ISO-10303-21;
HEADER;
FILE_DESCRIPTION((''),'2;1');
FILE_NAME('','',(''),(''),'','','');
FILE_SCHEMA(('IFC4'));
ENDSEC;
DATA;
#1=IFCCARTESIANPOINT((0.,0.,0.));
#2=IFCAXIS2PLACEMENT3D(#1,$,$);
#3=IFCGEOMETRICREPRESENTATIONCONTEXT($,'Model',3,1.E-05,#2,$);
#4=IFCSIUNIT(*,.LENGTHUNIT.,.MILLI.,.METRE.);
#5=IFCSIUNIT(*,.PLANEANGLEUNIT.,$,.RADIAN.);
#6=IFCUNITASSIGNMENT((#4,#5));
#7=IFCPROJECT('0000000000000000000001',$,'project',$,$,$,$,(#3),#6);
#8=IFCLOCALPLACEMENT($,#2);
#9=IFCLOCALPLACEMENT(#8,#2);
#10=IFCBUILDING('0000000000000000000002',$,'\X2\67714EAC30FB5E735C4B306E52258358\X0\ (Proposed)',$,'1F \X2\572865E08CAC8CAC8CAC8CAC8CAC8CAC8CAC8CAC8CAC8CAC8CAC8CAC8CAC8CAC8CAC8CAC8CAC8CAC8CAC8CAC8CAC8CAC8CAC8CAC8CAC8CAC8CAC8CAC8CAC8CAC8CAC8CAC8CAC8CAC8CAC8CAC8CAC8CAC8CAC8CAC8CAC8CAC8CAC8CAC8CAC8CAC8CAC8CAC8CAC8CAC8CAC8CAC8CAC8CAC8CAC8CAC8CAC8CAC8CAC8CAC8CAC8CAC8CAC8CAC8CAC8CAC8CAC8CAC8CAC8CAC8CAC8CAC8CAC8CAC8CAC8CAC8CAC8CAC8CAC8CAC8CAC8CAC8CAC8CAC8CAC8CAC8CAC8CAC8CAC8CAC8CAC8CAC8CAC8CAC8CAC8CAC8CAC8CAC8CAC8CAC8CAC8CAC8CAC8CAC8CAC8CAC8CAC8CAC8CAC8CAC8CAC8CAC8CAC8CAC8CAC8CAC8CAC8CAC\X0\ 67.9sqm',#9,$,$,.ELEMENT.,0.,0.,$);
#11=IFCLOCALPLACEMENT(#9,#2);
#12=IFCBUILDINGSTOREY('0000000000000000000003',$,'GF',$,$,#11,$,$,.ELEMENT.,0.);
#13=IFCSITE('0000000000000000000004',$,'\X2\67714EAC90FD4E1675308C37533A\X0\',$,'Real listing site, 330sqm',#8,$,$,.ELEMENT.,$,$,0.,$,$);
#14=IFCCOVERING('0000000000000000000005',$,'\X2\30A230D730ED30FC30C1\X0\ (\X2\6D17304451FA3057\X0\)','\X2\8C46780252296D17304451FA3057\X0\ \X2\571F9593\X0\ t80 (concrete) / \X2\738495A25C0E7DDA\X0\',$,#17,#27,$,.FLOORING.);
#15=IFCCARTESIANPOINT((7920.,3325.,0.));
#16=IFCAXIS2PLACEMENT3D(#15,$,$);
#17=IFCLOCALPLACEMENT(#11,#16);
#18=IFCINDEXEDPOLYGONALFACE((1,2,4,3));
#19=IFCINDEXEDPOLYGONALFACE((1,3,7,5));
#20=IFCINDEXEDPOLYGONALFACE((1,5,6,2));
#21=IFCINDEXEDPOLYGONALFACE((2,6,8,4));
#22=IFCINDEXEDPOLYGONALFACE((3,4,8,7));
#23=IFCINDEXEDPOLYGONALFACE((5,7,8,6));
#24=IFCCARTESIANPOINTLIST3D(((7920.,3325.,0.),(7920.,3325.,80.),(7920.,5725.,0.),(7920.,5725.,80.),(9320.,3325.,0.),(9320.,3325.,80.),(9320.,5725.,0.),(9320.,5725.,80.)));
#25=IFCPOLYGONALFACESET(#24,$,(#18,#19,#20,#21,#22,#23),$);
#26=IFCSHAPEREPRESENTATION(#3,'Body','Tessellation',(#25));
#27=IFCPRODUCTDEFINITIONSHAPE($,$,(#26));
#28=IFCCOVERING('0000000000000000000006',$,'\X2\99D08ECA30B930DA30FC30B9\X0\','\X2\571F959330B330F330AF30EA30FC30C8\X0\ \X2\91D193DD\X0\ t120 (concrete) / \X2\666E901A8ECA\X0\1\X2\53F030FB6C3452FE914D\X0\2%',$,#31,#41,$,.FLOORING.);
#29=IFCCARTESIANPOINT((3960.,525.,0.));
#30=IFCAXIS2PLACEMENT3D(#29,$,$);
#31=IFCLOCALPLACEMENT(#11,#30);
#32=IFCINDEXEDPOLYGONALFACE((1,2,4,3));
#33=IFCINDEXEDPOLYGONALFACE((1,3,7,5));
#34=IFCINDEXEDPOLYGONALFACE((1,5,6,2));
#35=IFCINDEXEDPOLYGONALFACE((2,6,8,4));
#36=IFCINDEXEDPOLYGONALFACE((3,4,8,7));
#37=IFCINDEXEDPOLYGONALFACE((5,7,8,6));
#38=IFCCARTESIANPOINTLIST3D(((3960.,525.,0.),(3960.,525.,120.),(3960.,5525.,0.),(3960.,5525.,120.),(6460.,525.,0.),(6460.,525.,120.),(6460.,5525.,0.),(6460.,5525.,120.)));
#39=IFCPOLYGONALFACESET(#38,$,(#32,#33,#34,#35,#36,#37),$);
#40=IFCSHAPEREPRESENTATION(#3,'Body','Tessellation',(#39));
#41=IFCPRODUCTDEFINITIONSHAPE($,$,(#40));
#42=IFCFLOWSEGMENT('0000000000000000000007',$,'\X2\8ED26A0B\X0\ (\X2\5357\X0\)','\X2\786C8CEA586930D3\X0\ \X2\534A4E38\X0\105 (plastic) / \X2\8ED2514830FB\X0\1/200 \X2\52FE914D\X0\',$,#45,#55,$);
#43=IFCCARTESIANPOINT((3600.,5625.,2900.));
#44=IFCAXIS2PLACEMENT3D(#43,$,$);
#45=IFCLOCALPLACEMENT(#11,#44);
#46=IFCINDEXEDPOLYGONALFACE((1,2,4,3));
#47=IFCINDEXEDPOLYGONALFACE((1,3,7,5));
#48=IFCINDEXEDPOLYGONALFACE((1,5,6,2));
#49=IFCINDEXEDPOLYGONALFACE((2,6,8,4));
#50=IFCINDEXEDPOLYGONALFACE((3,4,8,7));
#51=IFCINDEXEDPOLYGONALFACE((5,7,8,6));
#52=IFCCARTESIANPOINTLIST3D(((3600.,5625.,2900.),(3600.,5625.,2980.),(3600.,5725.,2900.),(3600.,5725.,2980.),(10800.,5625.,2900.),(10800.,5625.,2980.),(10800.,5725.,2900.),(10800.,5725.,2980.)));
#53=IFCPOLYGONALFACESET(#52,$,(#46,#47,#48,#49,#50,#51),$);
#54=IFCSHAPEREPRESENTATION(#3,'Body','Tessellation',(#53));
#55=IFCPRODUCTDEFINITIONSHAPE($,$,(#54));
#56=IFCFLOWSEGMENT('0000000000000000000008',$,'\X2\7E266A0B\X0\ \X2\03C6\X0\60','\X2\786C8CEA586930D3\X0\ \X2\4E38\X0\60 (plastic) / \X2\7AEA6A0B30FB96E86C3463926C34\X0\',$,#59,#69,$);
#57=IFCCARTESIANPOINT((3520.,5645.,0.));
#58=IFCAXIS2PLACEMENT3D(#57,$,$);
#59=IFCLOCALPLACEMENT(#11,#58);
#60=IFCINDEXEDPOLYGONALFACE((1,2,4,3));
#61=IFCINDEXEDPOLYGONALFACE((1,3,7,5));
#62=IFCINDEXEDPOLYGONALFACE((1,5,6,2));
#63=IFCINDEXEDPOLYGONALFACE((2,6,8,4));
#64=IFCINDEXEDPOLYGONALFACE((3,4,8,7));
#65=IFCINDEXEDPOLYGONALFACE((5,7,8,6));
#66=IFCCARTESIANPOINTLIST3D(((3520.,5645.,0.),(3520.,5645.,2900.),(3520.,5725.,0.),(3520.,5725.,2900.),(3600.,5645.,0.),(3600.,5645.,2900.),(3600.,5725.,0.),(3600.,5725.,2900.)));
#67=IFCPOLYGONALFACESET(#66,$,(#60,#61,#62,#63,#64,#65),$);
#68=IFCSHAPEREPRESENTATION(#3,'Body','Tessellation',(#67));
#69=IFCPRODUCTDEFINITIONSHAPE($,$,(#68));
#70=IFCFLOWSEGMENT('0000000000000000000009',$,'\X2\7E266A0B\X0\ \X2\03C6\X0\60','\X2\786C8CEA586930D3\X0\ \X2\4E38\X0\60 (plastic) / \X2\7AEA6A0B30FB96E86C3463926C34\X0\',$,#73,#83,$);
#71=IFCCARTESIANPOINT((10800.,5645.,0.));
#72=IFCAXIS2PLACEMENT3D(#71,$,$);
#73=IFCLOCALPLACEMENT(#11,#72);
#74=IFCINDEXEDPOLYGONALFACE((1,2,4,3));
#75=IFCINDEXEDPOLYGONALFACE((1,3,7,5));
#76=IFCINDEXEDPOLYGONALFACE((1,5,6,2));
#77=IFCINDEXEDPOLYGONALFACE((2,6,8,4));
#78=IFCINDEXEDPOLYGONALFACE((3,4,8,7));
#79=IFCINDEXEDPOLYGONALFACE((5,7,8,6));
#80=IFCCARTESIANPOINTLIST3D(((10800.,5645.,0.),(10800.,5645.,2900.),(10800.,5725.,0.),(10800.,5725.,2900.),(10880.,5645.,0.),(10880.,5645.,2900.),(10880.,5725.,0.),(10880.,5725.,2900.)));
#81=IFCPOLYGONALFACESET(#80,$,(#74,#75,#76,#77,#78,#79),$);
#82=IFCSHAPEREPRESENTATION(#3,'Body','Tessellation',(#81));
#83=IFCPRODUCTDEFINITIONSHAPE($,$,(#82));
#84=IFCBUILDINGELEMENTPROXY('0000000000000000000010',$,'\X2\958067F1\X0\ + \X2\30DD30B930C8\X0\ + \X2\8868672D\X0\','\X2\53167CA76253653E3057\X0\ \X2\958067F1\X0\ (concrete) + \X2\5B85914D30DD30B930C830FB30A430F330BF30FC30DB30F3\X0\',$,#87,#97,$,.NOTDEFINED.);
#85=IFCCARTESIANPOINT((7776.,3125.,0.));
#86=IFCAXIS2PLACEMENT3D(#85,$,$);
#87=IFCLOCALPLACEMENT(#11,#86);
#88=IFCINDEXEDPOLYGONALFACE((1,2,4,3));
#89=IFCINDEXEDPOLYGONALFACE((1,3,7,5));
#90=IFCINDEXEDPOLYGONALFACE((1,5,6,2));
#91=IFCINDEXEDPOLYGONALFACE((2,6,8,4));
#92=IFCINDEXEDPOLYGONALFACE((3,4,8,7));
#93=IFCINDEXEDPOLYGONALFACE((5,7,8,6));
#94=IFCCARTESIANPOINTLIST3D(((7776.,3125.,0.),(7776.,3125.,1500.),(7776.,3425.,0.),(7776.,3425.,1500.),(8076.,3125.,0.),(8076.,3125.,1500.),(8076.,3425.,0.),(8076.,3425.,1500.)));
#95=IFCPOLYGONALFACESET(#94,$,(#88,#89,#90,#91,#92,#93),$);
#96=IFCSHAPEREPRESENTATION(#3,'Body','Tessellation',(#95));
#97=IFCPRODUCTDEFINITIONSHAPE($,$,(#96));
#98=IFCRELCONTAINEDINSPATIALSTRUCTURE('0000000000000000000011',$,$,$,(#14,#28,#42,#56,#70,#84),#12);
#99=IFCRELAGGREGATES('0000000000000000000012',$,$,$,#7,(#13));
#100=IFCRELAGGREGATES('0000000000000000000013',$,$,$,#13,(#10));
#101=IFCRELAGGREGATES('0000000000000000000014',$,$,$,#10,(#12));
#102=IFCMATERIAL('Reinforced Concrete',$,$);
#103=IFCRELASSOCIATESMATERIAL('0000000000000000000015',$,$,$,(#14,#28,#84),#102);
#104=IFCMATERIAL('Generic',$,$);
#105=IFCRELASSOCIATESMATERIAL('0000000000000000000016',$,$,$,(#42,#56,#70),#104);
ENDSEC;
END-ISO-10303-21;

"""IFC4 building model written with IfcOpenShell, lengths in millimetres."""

from ifc_helpers import new_model, si_unit, frame, frame_2d, origin, place, context, project, spatial, rectangle, extrude, material, element, save


model = new_model("IFC4")

# Units and contexts
model_context = context("Model", 3, precision=1e-05, world=origin())
ifc_project = project(units=[si_unit("LENGTHUNIT", "METRE", prefix="MILLI"), si_unit("PLANEANGLEUNIT", "RADIAN")], contexts=[model_context])

# Site, building, storey
site_placement = place(None, origin())
site = spatial("IfcSite", under=ifc_project, at=site_placement, Name="東京都世田谷区", ObjectType="Real listing site, 330sqm", CompositionType="ELEMENT", RefElevation=0.0)
building_placement = place(site_placement, origin())
building = spatial("IfcBuilding", under=site, at=building_placement, Name="東京・平屋の別荘 (Proposed)", ObjectType="1F 在无責責責責責責責責責責責責責責責責責責責責責責責責責責責責責責責責責責責責責責責責責責責責責責責責責責責責責責責責責責責責責責責責責責責責責責責責責責責責責責責責責責責責責責責責責責責責責責責責責責責責責責責責責責責責責責責責責責責責責責 67.9sqm", CompositionType="ELEMENT", ElevationOfRefHeight=0.0, ElevationOfTerrain=0.0)
storey_placement = place(building_placement, origin())
storey = spatial("IfcBuildingStorey", under=building, at=storey_placement, Name="GF", CompositionType="ELEMENT", Elevation=0.0)

# Shared definitions
ifc_material_1 = material(Name="Reinforced Concrete")

# Coverings
ifc_material_2 = material(Name="Generic")
covering_1_placement = place(storey_placement, frame((7920.0, 3325.0, 0.0)))
element("IfcCovering", 1, at=covering_1_placement, inside=storey, material=ifc_material_1, Name="アプローチ (洗い出し)", Description="豆砂利洗い出し 土間 t80 (concrete) / 玄関導線", PredefinedType="FLOORING", context=model_context, shape_type="SweptSolid", body=[
    extrude(rectangle(XDim=1400.0, YDim=2400.0, at=frame_2d((700.0, 1200.0))), frame((7920.0, 3325.0, 0.0)), (0.0, 0.0, 1.0), 80.0),
])
covering_2_placement = place(storey_placement, frame((3960.0, 525.0, 0.0)))
element("IfcCovering", 2, at=covering_2_placement, inside=storey, material=ifc_material_1, Name="駐車スペース", Description="土間コンクリート 金鏝 t120 (concrete) / 普通車1台・水勾配2%", PredefinedType="FLOORING", context=model_context, shape_type="SweptSolid", body=[
    extrude(rectangle(XDim=2500.0, YDim=5000.0, at=frame_2d((1250.0, 2500.0))), frame((3960.0, 525.0, 0.0)), (0.0, 0.0, 1.0), 120.0),
])

# Flow segments
flow_segment_1_placement = place(storey_placement, frame((3600.0, 5625.0, 2900.0)))
element("IfcFlowSegment", 3, at=flow_segment_1_placement, inside=storey, material=ifc_material_2, Name="軒樋 (南)", Description="硬質塩ビ 半丸105 (plastic) / 軒先・1/200 勾配", context=model_context, shape_type="SweptSolid", body=[
    extrude(rectangle(XDim=7200.0, YDim=100.0, at=frame_2d((3600.0, 50.0))), frame((3600.0, 5625.0, 2900.0)), (0.0, 0.0, 1.0), 80.0),
])
flow_segment_2_placement = place(storey_placement, frame((3520.0, 5645.0, 0.0)))
element("IfcFlowSegment", 4, at=flow_segment_2_placement, inside=storey, material=ifc_material_2, Name="縦樋 φ60", Description="硬質塩ビ 丸60 (plastic) / 竪樋・雨水排水", context=model_context, shape_type="SweptSolid", body=[
    extrude(rectangle(XDim=80.0, YDim=80.0, at=frame_2d((40.0, 40.0))), frame((3520.0, 5645.0, 0.0)), (0.0, 0.0, 1.0), 2900.0),
])
flow_segment_3_placement = place(storey_placement, frame((10800.0, 5645.0, 0.0)))
element("IfcFlowSegment", 5, at=flow_segment_3_placement, inside=storey, material=ifc_material_2, Name="縦樋 φ60", Description="硬質塩ビ 丸60 (plastic) / 竪樋・雨水排水", context=model_context, shape_type="SweptSolid", body=[
    extrude(rectangle(XDim=80.0, YDim=80.0, at=frame_2d((40.0, 40.0))), frame((10800.0, 5645.0, 0.0)), (0.0, 0.0, 1.0), 2900.0),
])

# Building element proxy
proxy_placement = place(storey_placement, frame((7776.0, 3125.0, 0.0)))
element("IfcBuildingElementProxy", 6, at=proxy_placement, inside=storey, material=ifc_material_1, Name="門柱 + ポスト + 表札", Description="化粧打放し 門柱 (concrete) + 宅配ポスト・インターホン", PredefinedType="NOTDEFINED", context=model_context, shape_type="SweptSolid", body=[
    extrude(rectangle(XDim=300.0, YDim=300.0, at=frame_2d((150.0, 150.0))), frame((7776.0, 3125.0, 0.0)), (0.0, 0.0, 1.0), 1500.0),
])

save(model, "model.ifc")
